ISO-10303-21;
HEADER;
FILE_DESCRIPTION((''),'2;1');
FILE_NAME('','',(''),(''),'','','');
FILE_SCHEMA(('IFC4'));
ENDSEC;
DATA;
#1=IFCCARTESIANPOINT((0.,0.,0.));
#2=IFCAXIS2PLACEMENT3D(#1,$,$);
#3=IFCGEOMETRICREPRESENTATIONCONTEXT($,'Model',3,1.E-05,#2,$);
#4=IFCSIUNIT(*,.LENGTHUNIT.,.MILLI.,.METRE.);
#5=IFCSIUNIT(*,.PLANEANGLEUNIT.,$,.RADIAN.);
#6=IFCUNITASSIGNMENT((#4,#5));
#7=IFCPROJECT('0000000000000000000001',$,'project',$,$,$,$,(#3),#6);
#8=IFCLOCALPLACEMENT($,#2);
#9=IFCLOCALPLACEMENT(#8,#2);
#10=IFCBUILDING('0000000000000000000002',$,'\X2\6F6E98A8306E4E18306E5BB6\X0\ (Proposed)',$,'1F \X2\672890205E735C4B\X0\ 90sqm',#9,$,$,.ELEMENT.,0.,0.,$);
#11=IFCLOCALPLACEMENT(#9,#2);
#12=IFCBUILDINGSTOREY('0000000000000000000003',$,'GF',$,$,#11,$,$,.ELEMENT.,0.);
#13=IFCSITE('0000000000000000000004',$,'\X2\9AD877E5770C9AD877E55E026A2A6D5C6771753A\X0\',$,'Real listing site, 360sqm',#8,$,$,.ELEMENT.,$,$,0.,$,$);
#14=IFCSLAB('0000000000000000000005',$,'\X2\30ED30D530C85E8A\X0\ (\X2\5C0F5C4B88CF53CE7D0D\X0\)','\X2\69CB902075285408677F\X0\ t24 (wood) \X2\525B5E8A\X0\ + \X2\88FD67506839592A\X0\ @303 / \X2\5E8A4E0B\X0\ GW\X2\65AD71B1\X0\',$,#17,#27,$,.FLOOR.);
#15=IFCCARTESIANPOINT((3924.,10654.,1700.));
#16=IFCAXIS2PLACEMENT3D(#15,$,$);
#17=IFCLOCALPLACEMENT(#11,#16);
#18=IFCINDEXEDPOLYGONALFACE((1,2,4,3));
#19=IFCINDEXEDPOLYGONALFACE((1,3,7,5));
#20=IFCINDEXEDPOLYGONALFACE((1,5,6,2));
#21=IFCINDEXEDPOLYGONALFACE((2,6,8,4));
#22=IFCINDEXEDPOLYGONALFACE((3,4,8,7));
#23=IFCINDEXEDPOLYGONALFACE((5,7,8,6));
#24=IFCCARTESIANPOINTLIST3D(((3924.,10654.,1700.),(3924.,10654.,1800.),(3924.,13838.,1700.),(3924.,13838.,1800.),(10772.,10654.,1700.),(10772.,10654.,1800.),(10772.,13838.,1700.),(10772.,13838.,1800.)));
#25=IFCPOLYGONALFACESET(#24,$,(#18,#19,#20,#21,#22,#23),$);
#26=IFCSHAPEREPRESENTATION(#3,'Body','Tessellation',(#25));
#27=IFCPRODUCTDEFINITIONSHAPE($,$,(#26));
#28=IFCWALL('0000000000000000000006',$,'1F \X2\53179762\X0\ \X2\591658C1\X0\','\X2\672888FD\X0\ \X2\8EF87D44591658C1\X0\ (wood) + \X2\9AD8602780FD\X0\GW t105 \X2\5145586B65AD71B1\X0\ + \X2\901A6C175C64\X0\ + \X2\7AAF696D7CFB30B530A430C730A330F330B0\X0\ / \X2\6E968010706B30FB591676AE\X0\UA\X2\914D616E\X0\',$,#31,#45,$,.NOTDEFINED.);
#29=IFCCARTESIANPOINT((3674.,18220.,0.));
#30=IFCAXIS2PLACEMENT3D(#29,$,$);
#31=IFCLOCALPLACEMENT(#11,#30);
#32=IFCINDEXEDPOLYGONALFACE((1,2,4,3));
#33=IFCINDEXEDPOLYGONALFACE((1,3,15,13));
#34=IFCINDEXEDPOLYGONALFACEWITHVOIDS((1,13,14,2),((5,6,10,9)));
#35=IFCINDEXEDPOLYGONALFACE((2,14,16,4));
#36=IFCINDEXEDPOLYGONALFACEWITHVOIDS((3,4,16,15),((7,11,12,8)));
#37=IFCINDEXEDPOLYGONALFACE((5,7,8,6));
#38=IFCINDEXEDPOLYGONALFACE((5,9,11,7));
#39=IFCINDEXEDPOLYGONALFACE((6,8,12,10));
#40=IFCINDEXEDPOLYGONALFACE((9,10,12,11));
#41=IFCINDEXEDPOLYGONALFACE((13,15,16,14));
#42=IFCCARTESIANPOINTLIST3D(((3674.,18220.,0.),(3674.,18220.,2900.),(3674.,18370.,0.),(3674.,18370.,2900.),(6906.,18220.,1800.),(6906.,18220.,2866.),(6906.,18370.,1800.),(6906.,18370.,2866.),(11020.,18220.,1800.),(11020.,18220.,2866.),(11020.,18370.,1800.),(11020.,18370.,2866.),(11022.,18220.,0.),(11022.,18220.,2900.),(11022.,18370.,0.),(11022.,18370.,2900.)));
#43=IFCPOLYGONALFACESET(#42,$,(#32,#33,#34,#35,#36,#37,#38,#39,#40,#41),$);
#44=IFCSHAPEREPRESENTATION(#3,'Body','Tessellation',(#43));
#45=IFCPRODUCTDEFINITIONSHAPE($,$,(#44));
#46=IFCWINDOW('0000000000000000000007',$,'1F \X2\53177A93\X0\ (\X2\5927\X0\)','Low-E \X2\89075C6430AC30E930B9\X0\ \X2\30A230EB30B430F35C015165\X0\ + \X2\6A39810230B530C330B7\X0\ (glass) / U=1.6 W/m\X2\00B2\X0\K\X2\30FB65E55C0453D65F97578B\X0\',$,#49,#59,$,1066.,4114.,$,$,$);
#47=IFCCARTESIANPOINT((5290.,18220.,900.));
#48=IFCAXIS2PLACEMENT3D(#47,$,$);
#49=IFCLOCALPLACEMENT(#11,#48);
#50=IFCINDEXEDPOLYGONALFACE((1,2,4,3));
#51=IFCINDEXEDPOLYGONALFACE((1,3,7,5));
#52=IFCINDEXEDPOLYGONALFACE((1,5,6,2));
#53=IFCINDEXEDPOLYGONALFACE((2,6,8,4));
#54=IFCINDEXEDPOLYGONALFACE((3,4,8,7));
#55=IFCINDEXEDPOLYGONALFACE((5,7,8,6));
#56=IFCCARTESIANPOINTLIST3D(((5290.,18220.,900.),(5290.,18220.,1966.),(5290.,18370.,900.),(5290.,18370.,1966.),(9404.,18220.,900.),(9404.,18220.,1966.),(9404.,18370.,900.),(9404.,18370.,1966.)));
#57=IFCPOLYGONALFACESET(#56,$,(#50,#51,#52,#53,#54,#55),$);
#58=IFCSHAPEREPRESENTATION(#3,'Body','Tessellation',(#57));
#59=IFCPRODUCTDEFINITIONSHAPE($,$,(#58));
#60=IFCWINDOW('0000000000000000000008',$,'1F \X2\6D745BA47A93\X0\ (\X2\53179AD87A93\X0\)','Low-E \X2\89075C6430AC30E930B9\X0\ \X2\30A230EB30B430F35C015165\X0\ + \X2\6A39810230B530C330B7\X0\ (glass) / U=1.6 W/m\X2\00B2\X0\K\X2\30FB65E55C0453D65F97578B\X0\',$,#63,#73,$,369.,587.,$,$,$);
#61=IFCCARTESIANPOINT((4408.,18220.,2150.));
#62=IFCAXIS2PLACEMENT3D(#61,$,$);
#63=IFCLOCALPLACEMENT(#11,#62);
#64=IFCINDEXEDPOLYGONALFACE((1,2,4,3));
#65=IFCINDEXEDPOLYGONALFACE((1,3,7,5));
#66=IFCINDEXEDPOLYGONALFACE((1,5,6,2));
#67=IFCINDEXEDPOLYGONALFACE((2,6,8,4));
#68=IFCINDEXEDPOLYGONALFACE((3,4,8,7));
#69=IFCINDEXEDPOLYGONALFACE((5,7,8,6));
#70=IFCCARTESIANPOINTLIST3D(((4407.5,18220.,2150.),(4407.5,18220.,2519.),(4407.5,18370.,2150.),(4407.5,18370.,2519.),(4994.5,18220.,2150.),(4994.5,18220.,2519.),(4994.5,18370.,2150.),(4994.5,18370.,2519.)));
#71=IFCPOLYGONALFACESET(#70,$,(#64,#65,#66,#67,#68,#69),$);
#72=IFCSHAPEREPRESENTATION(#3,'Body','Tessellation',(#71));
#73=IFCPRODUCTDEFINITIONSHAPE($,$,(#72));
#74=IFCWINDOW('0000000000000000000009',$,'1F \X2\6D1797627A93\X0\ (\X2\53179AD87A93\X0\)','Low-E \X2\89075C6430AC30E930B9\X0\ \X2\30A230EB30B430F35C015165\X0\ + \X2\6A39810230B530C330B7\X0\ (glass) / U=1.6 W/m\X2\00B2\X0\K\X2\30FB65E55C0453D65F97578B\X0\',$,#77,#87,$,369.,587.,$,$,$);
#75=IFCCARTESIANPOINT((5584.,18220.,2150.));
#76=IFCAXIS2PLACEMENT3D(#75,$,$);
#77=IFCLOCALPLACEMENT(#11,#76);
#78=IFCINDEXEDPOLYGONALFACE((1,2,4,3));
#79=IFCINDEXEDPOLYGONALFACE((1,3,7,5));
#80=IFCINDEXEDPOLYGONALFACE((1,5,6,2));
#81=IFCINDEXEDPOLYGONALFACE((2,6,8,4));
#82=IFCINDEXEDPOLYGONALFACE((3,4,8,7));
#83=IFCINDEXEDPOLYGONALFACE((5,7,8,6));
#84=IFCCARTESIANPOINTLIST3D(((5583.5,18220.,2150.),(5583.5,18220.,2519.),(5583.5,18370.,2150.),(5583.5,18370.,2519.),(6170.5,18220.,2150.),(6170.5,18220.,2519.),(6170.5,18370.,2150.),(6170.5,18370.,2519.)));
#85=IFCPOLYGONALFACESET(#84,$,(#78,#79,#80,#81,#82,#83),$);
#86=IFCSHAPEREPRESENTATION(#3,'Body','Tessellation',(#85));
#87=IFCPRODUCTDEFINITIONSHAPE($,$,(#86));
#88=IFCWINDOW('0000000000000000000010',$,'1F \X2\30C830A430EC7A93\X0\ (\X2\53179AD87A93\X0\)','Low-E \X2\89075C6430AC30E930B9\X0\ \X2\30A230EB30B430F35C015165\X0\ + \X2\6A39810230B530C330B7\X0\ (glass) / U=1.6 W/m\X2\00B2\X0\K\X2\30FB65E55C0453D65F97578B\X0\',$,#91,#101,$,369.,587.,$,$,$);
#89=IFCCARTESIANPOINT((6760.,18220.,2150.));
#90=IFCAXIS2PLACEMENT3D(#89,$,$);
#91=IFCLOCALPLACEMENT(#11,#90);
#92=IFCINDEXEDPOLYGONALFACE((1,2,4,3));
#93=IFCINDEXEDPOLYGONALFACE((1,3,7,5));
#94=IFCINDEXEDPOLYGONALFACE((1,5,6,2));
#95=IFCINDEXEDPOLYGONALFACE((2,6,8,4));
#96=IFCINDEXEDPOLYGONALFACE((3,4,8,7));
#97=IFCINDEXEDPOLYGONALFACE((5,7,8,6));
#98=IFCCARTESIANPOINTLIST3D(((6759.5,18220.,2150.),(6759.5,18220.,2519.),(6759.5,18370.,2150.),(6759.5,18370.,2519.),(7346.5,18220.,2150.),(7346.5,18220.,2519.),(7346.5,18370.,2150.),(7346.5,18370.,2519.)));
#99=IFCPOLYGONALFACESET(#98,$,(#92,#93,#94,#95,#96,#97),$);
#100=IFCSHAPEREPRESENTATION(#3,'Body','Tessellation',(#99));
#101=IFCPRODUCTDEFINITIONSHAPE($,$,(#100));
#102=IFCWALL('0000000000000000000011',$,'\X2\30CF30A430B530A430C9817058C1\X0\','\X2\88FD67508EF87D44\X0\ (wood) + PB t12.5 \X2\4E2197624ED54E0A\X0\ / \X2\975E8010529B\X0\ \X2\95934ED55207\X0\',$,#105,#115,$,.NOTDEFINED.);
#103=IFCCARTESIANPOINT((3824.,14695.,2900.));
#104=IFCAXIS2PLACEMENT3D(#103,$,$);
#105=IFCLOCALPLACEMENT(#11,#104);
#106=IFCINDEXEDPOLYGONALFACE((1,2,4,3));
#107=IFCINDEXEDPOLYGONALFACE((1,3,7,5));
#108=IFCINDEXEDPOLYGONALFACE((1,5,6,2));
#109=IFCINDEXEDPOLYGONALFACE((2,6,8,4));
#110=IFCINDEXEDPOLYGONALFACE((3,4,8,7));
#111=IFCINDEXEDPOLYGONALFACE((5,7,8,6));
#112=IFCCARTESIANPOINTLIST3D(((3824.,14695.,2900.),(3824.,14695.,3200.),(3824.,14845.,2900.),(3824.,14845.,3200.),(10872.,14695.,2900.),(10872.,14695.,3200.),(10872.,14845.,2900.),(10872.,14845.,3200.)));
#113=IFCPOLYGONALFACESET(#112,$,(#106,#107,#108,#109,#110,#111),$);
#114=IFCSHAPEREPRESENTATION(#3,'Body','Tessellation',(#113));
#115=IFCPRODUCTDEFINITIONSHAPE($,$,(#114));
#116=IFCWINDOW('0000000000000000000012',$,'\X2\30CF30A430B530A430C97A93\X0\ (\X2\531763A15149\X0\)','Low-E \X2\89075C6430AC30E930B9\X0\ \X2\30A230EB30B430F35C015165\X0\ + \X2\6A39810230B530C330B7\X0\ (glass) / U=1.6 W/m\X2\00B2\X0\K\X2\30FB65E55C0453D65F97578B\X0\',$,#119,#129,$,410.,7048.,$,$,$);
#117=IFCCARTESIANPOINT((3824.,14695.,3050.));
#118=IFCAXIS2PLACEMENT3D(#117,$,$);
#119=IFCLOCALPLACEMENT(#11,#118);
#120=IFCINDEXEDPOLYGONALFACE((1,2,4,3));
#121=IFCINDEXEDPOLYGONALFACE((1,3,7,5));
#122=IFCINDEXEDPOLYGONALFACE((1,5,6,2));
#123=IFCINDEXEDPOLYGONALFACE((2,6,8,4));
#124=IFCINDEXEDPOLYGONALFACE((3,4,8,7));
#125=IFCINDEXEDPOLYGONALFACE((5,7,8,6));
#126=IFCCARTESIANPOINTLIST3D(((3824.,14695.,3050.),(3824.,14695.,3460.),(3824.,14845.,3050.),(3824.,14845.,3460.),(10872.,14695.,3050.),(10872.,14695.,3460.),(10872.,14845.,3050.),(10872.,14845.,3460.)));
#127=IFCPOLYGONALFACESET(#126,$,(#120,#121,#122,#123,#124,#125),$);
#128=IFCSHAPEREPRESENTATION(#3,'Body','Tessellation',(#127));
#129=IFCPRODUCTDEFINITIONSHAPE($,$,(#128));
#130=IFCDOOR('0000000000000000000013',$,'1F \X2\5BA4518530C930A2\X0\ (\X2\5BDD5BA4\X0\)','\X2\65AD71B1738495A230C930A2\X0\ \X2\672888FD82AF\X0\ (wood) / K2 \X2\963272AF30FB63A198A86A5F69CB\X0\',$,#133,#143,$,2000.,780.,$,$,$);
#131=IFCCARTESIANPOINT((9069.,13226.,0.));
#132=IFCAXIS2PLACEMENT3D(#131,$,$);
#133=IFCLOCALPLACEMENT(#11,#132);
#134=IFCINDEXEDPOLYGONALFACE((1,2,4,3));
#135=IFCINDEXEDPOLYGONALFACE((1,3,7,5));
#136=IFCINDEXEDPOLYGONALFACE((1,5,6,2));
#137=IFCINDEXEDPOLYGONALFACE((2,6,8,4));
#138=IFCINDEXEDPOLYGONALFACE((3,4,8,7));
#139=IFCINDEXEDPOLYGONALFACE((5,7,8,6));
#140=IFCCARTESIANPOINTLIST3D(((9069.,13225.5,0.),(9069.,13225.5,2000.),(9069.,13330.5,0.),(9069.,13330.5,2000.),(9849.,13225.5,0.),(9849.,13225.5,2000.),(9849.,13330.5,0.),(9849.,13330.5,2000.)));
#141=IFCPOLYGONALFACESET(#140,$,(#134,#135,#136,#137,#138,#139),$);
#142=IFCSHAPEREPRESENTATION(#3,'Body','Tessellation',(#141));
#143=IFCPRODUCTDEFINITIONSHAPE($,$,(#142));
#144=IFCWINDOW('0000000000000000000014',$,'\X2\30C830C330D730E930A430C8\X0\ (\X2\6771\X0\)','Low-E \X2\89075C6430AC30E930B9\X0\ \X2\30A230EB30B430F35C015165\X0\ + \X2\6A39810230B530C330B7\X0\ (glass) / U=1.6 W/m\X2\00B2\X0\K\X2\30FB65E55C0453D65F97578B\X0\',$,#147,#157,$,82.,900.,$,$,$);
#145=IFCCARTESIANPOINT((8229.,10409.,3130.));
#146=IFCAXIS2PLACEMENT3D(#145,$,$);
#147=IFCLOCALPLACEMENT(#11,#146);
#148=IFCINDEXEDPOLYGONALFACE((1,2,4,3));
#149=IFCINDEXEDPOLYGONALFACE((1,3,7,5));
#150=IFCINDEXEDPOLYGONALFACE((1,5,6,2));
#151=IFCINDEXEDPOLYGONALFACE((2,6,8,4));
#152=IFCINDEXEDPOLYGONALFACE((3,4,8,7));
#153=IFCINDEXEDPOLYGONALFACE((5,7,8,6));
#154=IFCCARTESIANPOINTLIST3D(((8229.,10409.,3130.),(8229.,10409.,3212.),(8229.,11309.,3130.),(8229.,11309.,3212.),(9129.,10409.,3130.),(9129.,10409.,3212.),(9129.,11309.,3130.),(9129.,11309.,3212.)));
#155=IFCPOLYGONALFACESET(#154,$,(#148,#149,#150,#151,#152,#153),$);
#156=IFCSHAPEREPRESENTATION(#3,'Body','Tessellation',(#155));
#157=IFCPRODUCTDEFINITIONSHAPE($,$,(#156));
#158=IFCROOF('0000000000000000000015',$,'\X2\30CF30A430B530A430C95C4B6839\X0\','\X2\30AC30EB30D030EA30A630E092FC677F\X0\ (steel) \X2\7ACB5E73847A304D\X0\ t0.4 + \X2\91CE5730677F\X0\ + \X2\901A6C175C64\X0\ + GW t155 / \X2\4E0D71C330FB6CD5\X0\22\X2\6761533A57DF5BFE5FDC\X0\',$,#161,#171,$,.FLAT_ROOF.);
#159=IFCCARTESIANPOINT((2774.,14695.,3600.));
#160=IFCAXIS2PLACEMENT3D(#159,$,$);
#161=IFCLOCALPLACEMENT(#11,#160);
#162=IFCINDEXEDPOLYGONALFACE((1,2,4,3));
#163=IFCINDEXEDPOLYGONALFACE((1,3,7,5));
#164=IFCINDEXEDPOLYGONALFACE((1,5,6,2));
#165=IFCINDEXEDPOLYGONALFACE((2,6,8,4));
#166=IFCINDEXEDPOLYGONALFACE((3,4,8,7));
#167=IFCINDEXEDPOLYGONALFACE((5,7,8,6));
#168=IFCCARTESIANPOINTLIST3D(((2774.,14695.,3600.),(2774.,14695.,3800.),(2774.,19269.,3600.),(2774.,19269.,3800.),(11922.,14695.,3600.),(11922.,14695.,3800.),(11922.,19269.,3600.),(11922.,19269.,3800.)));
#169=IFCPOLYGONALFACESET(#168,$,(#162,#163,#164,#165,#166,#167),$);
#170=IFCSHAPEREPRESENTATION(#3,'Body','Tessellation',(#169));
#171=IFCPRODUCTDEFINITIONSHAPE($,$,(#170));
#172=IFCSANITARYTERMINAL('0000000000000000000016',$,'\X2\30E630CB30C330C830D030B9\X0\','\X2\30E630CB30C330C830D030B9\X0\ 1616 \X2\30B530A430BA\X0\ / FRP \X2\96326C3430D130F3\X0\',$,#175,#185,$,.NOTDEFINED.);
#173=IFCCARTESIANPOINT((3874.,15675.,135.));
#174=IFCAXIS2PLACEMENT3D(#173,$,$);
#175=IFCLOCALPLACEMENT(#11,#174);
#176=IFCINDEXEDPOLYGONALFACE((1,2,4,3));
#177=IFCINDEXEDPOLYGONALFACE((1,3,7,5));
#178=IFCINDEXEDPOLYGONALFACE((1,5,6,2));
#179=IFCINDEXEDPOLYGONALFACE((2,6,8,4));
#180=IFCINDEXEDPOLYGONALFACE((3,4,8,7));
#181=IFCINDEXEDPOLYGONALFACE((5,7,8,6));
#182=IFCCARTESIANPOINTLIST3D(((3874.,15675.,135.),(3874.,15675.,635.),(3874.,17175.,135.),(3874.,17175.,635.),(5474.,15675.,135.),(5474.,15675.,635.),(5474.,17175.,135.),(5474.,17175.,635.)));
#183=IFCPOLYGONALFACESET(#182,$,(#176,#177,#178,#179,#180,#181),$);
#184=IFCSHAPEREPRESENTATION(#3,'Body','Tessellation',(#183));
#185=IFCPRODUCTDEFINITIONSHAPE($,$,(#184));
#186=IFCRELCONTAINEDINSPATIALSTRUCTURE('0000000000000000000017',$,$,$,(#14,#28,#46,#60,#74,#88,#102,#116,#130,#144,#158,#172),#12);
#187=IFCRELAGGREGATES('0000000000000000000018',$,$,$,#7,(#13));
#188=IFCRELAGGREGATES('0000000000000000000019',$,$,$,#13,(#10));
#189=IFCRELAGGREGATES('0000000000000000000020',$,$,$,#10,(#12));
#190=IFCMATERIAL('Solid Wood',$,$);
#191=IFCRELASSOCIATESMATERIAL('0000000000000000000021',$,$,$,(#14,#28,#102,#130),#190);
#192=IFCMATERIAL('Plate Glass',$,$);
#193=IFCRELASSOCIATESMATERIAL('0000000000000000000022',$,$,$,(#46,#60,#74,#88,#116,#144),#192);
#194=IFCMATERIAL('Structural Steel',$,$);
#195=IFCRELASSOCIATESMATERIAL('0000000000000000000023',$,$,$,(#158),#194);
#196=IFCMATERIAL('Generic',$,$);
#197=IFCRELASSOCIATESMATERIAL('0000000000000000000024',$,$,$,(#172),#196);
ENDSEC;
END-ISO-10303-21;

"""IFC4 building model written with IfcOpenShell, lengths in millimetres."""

from ifc_helpers import new_model, si_unit, frame, frame_2d, origin, place, context, project, spatial, rectangle, extrude, material, element, fill, save


model = new_model("IFC4")

# Units and contexts
model_context = context("Model", 3, precision=1e-05, world=origin())
ifc_project = project(units=[si_unit("LENGTHUNIT", "METRE", prefix="MILLI"), si_unit("PLANEANGLEUNIT", "RADIAN")], contexts=[model_context])

# Site, building, storey
site_placement = place(None, origin())
site = spatial("IfcSite", under=ifc_project, at=site_placement, Name="高知県高知市横浜東町", ObjectType="Real listing site, 360sqm", CompositionType="ELEMENT", RefElevation=0.0)
building_placement = place(site_placement, origin())
building = spatial("IfcBuilding", under=site, at=building_placement, Name="潮風の丘の家 (Proposed)", ObjectType="1F 木造平屋 90sqm", CompositionType="ELEMENT", ElevationOfRefHeight=0.0, ElevationOfTerrain=0.0)
storey_placement = place(building_placement, origin())
storey = spatial("IfcBuildingStorey", under=building, at=storey_placement, Name="GF", CompositionType="ELEMENT", Elevation=0.0)

# Slab
ifc_material_1 = material(Name="Solid Wood")
slab_placement = place(storey_placement, frame((3924.0, 10654.0, 1700.0)))
element("IfcSlab", 1, at=slab_placement, inside=storey, material=ifc_material_1, Name="ロフト床 (小屋裏収納)", Description="構造用合板 t24 (wood) 剛床 + 製材根太 @303 / 床下 GW断熱", PredefinedType="FLOOR", context=model_context, shape_type="SweptSolid", body=[
    extrude(rectangle(XDim=6848.0, YDim=3184.0, at=frame_2d((3424.0, 1592.0))), frame((3924.0, 10654.0, 1700.0)), (0.0, 0.0, 1.0), 100.0),
])

# Wall, openings, windows
wall_1_placement = place(storey_placement, frame((3674.0, 18220.0, 0.0)))
wall_1 = element("IfcWall", 2, at=wall_1_placement, inside=storey, material=ifc_material_1, Name="1F 北面 外壁", Description="木製 軸組外壁 (wood) + 高性能GW t105 充填断熱 + 通気層 + 窯業系サイディング / 準耐火・外皮UA配慮", PredefinedType="NOTDEFINED", context=model_context, shape_type="SweptSolid", body=[
    extrude(rectangle(XDim=7348.0, YDim=150.0, at=frame_2d((3674.0, 75.0))), frame((3674.0, 18220.0, 0.0)), (0.0, 0.0, 1.0), 2900.0),
])
opening_1_placement = place(storey_placement, frame((5290.0, 18220.0, 900.0)))
opening_1 = element("IfcOpeningElement", 3, at=opening_1_placement, cuts=wall_1, PredefinedType="NOTDEFINED", context=model_context, shape_type="SweptSolid", body=[
    extrude(rectangle(XDim=4114.0, YDim=150.0, at=frame_2d((2057.0, 75.0))), frame((5290.0, 18220.0, 900.0)), (0.0, 0.0, 1.0), 1066.0),
])
opening_2_placement = place(storey_placement, frame((4408.0, 18220.0, 2150.0)))
opening_2 = element("IfcOpeningElement", 4, at=opening_2_placement, cuts=wall_1, PredefinedType="NOTDEFINED", context=model_context, shape_type="SweptSolid", body=[
    extrude(rectangle(XDim=587.0, YDim=150.0, at=frame_2d((293.0, 75.0))), frame((4408.0, 18220.0, 2150.0)), (0.0, 0.0, 1.0), 369.0),
])
opening_3_placement = place(storey_placement, frame((5584.0, 18220.0, 2150.0)))
opening_3 = element("IfcOpeningElement", 5, at=opening_3_placement, cuts=wall_1, PredefinedType="NOTDEFINED", context=model_context, shape_type="SweptSolid", body=[
    extrude(rectangle(XDim=587.0, YDim=150.0, at=frame_2d((293.0, 75.0))), frame((5584.0, 18220.0, 2150.0)), (0.0, 0.0, 1.0), 369.0),
])
opening_4_placement = place(storey_placement, frame((6760.0, 18220.0, 2150.0)))
opening_4 = element("IfcOpeningElement", 6, at=opening_4_placement, cuts=wall_1, PredefinedType="NOTDEFINED", context=model_context, shape_type="SweptSolid", body=[
    extrude(rectangle(XDim=587.0, YDim=150.0, at=frame_2d((293.0, 75.0))), frame((6760.0, 18220.0, 2150.0)), (0.0, 0.0, 1.0), 369.0),
])
ifc_material_2 = material(Name="Plate Glass")
window_1_placement = place(storey_placement, frame((5290.0, 18220.0, 900.0)))
window_1 = element("IfcWindow", 7, at=window_1_placement, inside=storey, material=ifc_material_2, Name="1F 北窓 (大)", Description="Low-E 複層ガラス アルゴン封入 + 樹脂サッシ (glass) / U=1.6 W/m²K・日射取得型", OverallHeight=1066.0, OverallWidth=4114.0, context=model_context, shape_type="SweptSolid", body=[
    extrude(rectangle(XDim=4114.0, YDim=150.0, at=frame_2d((2057.0, 75.0))), frame((5290.0, 18220.0, 900.0)), (0.0, 0.0, 1.0), 1066.0),
])
fill(opening_1, window_1)
window_2_placement = place(storey_placement, frame((4408.0, 18220.0, 2150.0)))
window_2 = element("IfcWindow", 8, at=window_2_placement, inside=storey, material=ifc_material_2, Name="1F 浴室窓 (北高窓)", Description="Low-E 複層ガラス アルゴン封入 + 樹脂サッシ (glass) / U=1.6 W/m²K・日射取得型", OverallHeight=369.0, OverallWidth=587.0, context=model_context, shape_type="SweptSolid", body=[
    extrude(rectangle(XDim=587.0, YDim=150.0, at=frame_2d((293.0, 75.0))), frame((4408.0, 18220.0, 2150.0)), (0.0, 0.0, 1.0), 369.0),
])
fill(opening_2, window_2)
window_3_placement = place(storey_placement, frame((5584.0, 18220.0, 2150.0)))
window_3 = element("IfcWindow", 9, at=window_3_placement, inside=storey, material=ifc_material_2, Name="1F 洗面窓 (北高窓)", Description="Low-E 複層ガラス アルゴン封入 + 樹脂サッシ (glass) / U=1.6 W/m²K・日射取得型", OverallHeight=369.0, OverallWidth=587.0, context=model_context, shape_type="SweptSolid", body=[
    extrude(rectangle(XDim=587.0, YDim=150.0, at=frame_2d((293.0, 75.0))), frame((5584.0, 18220.0, 2150.0)), (0.0, 0.0, 1.0), 369.0),
])
fill(opening_3, window_3)
window_4_placement = place(storey_placement, frame((6760.0, 18220.0, 2150.0)))
window_4 = element("IfcWindow", 10, at=window_4_placement, inside=storey, material=ifc_material_2, Name="1F トイレ窓 (北高窓)", Description="Low-E 複層ガラス アルゴン封入 + 樹脂サッシ (glass) / U=1.6 W/m²K・日射取得型", OverallHeight=369.0, OverallWidth=587.0, context=model_context, shape_type="SweptSolid", body=[
    extrude(rectangle(XDim=587.0, YDim=150.0, at=frame_2d((293.0, 75.0))), frame((6760.0, 18220.0, 2150.0)), (0.0, 0.0, 1.0), 369.0),
])
fill(opening_4, window_4)

# Wall, opening, window
wall_2_placement = place(storey_placement, frame((3824.0, 14695.0, 2900.0)))
wall_2 = element("IfcWall", 11, at=wall_2_placement, inside=storey, material=ifc_material_1, Name="ハイサイド腰壁", Description="製材軸組 (wood) + PB t12.5 両面仕上 / 非耐力 間仕切", PredefinedType="NOTDEFINED", context=model_context, shape_type="SweptSolid", body=[
    extrude(rectangle(XDim=7048.0, YDim=150.0, at=frame_2d((3524.0, 75.0))), frame((3824.0, 14695.0, 2900.0)), (0.0, 0.0, 1.0), 700.0),
])
opening_5_placement = place(storey_placement, frame((3824.0, 14695.0, 3050.0)))
opening_5 = element("IfcOpeningElement", 12, at=opening_5_placement, cuts=wall_2, PredefinedType="NOTDEFINED", context=model_context, shape_type="SweptSolid", body=[
    extrude(rectangle(XDim=7048.0, YDim=150.0, at=frame_2d((3524.0, 75.0))), frame((3824.0, 14695.0, 3050.0)), (0.0, 0.0, 1.0), 410.0),
])
window_5_placement = place(storey_placement, frame((3824.0, 14695.0, 3050.0)))
window_5 = element("IfcWindow", 13, at=window_5_placement, inside=storey, material=ifc_material_2, Name="ハイサイド窓 (北採光)", Description="Low-E 複層ガラス アルゴン封入 + 樹脂サッシ (glass) / U=1.6 W/m²K・日射取得型", OverallHeight=410.0, OverallWidth=7048.0, context=model_context, shape_type="SweptSolid", body=[
    extrude(rectangle(XDim=7048.0, YDim=150.0, at=frame_2d((3524.0, 75.0))), frame((3824.0, 14695.0, 3050.0)), (0.0, 0.0, 1.0), 410.0),
])
fill(opening_5, window_5)

# Door
door_1_placement = place(storey_placement, frame((9069.0, 13226.0, 0.0)))
element("IfcDoor", 14, at=door_1_placement, inside=storey, material=ifc_material_1, Name="1F 室内ドア (寝室)", Description="断熱玄関ドア 木製芯 (wood) / K2 防犯・採風機構", OverallHeight=2000.0, OverallWidth=780.0, context=model_context, shape_type="SweptSolid", body=[
    extrude(rectangle(XDim=780.0, YDim=105.0, at=frame_2d((390.0, 52.0))), frame((9069.0, 13226.0, 0.0)), (0.0, 0.0, 1.0), 2000.0),
])

# Window
window_6_placement = place(storey_placement, frame((8229.0, 10409.0, 3130.0)))
element("IfcWindow", 15, at=window_6_placement, inside=storey, material=ifc_material_2, Name="トップライト (東)", Description="Low-E 複層ガラス アルゴン封入 + 樹脂サッシ (glass) / U=1.6 W/m²K・日射取得型", OverallHeight=82.0, OverallWidth=900.0, context=model_context, shape_type="SweptSolid", body=[
    extrude(rectangle(XDim=900.0, YDim=900.0, at=frame_2d((450.0, 450.0))), frame((8229.0, 10409.0, 3130.0)), (0.0, 0.0, 1.0), 82.0),
])

# Roof
ifc_material_3 = material(Name="Structural Steel")
roof_placement = place(storey_placement, frame((2774.0, 14695.0, 3600.0)))
element("IfcRoof", 16, at=roof_placement, inside=storey, material=ifc_material_3, Name="ハイサイド屋根", Description="ガルバリウム鋼板 (steel) 立平葺き t0.4 + 野地板 + 通気層 + GW t155 / 不燃・法22条区域対応", PredefinedType="FLAT_ROOF", context=model_context, shape_type="SweptSolid", body=[
    extrude(rectangle(XDim=9148.0, YDim=4574.0, at=frame_2d((4574.0, 2287.0))), frame((2774.0, 14695.0, 3600.0)), (0.0, 0.0, 1.0), 200.0),
])

# Sanitary terminal
ifc_material_4 = material(Name="Generic")
sanitary_terminal_1_placement = place(storey_placement, frame((3874.0, 15675.0, 135.0)))
element("IfcSanitaryTerminal", 17, at=sanitary_terminal_1_placement, inside=storey, material=ifc_material_4, Name="ユニットバス", Description="ユニットバス 1616 サイズ / FRP 防水パン", PredefinedType="NOTDEFINED", context=model_context, shape_type="SweptSolid", body=[
    extrude(rectangle(XDim=1600.0, YDim=1500.0, at=frame_2d((800.0, 750.0))), frame((3874.0, 15675.0, 135.0)), (0.0, 0.0, 1.0), 500.0),
])

save(model, "model.ifc")
